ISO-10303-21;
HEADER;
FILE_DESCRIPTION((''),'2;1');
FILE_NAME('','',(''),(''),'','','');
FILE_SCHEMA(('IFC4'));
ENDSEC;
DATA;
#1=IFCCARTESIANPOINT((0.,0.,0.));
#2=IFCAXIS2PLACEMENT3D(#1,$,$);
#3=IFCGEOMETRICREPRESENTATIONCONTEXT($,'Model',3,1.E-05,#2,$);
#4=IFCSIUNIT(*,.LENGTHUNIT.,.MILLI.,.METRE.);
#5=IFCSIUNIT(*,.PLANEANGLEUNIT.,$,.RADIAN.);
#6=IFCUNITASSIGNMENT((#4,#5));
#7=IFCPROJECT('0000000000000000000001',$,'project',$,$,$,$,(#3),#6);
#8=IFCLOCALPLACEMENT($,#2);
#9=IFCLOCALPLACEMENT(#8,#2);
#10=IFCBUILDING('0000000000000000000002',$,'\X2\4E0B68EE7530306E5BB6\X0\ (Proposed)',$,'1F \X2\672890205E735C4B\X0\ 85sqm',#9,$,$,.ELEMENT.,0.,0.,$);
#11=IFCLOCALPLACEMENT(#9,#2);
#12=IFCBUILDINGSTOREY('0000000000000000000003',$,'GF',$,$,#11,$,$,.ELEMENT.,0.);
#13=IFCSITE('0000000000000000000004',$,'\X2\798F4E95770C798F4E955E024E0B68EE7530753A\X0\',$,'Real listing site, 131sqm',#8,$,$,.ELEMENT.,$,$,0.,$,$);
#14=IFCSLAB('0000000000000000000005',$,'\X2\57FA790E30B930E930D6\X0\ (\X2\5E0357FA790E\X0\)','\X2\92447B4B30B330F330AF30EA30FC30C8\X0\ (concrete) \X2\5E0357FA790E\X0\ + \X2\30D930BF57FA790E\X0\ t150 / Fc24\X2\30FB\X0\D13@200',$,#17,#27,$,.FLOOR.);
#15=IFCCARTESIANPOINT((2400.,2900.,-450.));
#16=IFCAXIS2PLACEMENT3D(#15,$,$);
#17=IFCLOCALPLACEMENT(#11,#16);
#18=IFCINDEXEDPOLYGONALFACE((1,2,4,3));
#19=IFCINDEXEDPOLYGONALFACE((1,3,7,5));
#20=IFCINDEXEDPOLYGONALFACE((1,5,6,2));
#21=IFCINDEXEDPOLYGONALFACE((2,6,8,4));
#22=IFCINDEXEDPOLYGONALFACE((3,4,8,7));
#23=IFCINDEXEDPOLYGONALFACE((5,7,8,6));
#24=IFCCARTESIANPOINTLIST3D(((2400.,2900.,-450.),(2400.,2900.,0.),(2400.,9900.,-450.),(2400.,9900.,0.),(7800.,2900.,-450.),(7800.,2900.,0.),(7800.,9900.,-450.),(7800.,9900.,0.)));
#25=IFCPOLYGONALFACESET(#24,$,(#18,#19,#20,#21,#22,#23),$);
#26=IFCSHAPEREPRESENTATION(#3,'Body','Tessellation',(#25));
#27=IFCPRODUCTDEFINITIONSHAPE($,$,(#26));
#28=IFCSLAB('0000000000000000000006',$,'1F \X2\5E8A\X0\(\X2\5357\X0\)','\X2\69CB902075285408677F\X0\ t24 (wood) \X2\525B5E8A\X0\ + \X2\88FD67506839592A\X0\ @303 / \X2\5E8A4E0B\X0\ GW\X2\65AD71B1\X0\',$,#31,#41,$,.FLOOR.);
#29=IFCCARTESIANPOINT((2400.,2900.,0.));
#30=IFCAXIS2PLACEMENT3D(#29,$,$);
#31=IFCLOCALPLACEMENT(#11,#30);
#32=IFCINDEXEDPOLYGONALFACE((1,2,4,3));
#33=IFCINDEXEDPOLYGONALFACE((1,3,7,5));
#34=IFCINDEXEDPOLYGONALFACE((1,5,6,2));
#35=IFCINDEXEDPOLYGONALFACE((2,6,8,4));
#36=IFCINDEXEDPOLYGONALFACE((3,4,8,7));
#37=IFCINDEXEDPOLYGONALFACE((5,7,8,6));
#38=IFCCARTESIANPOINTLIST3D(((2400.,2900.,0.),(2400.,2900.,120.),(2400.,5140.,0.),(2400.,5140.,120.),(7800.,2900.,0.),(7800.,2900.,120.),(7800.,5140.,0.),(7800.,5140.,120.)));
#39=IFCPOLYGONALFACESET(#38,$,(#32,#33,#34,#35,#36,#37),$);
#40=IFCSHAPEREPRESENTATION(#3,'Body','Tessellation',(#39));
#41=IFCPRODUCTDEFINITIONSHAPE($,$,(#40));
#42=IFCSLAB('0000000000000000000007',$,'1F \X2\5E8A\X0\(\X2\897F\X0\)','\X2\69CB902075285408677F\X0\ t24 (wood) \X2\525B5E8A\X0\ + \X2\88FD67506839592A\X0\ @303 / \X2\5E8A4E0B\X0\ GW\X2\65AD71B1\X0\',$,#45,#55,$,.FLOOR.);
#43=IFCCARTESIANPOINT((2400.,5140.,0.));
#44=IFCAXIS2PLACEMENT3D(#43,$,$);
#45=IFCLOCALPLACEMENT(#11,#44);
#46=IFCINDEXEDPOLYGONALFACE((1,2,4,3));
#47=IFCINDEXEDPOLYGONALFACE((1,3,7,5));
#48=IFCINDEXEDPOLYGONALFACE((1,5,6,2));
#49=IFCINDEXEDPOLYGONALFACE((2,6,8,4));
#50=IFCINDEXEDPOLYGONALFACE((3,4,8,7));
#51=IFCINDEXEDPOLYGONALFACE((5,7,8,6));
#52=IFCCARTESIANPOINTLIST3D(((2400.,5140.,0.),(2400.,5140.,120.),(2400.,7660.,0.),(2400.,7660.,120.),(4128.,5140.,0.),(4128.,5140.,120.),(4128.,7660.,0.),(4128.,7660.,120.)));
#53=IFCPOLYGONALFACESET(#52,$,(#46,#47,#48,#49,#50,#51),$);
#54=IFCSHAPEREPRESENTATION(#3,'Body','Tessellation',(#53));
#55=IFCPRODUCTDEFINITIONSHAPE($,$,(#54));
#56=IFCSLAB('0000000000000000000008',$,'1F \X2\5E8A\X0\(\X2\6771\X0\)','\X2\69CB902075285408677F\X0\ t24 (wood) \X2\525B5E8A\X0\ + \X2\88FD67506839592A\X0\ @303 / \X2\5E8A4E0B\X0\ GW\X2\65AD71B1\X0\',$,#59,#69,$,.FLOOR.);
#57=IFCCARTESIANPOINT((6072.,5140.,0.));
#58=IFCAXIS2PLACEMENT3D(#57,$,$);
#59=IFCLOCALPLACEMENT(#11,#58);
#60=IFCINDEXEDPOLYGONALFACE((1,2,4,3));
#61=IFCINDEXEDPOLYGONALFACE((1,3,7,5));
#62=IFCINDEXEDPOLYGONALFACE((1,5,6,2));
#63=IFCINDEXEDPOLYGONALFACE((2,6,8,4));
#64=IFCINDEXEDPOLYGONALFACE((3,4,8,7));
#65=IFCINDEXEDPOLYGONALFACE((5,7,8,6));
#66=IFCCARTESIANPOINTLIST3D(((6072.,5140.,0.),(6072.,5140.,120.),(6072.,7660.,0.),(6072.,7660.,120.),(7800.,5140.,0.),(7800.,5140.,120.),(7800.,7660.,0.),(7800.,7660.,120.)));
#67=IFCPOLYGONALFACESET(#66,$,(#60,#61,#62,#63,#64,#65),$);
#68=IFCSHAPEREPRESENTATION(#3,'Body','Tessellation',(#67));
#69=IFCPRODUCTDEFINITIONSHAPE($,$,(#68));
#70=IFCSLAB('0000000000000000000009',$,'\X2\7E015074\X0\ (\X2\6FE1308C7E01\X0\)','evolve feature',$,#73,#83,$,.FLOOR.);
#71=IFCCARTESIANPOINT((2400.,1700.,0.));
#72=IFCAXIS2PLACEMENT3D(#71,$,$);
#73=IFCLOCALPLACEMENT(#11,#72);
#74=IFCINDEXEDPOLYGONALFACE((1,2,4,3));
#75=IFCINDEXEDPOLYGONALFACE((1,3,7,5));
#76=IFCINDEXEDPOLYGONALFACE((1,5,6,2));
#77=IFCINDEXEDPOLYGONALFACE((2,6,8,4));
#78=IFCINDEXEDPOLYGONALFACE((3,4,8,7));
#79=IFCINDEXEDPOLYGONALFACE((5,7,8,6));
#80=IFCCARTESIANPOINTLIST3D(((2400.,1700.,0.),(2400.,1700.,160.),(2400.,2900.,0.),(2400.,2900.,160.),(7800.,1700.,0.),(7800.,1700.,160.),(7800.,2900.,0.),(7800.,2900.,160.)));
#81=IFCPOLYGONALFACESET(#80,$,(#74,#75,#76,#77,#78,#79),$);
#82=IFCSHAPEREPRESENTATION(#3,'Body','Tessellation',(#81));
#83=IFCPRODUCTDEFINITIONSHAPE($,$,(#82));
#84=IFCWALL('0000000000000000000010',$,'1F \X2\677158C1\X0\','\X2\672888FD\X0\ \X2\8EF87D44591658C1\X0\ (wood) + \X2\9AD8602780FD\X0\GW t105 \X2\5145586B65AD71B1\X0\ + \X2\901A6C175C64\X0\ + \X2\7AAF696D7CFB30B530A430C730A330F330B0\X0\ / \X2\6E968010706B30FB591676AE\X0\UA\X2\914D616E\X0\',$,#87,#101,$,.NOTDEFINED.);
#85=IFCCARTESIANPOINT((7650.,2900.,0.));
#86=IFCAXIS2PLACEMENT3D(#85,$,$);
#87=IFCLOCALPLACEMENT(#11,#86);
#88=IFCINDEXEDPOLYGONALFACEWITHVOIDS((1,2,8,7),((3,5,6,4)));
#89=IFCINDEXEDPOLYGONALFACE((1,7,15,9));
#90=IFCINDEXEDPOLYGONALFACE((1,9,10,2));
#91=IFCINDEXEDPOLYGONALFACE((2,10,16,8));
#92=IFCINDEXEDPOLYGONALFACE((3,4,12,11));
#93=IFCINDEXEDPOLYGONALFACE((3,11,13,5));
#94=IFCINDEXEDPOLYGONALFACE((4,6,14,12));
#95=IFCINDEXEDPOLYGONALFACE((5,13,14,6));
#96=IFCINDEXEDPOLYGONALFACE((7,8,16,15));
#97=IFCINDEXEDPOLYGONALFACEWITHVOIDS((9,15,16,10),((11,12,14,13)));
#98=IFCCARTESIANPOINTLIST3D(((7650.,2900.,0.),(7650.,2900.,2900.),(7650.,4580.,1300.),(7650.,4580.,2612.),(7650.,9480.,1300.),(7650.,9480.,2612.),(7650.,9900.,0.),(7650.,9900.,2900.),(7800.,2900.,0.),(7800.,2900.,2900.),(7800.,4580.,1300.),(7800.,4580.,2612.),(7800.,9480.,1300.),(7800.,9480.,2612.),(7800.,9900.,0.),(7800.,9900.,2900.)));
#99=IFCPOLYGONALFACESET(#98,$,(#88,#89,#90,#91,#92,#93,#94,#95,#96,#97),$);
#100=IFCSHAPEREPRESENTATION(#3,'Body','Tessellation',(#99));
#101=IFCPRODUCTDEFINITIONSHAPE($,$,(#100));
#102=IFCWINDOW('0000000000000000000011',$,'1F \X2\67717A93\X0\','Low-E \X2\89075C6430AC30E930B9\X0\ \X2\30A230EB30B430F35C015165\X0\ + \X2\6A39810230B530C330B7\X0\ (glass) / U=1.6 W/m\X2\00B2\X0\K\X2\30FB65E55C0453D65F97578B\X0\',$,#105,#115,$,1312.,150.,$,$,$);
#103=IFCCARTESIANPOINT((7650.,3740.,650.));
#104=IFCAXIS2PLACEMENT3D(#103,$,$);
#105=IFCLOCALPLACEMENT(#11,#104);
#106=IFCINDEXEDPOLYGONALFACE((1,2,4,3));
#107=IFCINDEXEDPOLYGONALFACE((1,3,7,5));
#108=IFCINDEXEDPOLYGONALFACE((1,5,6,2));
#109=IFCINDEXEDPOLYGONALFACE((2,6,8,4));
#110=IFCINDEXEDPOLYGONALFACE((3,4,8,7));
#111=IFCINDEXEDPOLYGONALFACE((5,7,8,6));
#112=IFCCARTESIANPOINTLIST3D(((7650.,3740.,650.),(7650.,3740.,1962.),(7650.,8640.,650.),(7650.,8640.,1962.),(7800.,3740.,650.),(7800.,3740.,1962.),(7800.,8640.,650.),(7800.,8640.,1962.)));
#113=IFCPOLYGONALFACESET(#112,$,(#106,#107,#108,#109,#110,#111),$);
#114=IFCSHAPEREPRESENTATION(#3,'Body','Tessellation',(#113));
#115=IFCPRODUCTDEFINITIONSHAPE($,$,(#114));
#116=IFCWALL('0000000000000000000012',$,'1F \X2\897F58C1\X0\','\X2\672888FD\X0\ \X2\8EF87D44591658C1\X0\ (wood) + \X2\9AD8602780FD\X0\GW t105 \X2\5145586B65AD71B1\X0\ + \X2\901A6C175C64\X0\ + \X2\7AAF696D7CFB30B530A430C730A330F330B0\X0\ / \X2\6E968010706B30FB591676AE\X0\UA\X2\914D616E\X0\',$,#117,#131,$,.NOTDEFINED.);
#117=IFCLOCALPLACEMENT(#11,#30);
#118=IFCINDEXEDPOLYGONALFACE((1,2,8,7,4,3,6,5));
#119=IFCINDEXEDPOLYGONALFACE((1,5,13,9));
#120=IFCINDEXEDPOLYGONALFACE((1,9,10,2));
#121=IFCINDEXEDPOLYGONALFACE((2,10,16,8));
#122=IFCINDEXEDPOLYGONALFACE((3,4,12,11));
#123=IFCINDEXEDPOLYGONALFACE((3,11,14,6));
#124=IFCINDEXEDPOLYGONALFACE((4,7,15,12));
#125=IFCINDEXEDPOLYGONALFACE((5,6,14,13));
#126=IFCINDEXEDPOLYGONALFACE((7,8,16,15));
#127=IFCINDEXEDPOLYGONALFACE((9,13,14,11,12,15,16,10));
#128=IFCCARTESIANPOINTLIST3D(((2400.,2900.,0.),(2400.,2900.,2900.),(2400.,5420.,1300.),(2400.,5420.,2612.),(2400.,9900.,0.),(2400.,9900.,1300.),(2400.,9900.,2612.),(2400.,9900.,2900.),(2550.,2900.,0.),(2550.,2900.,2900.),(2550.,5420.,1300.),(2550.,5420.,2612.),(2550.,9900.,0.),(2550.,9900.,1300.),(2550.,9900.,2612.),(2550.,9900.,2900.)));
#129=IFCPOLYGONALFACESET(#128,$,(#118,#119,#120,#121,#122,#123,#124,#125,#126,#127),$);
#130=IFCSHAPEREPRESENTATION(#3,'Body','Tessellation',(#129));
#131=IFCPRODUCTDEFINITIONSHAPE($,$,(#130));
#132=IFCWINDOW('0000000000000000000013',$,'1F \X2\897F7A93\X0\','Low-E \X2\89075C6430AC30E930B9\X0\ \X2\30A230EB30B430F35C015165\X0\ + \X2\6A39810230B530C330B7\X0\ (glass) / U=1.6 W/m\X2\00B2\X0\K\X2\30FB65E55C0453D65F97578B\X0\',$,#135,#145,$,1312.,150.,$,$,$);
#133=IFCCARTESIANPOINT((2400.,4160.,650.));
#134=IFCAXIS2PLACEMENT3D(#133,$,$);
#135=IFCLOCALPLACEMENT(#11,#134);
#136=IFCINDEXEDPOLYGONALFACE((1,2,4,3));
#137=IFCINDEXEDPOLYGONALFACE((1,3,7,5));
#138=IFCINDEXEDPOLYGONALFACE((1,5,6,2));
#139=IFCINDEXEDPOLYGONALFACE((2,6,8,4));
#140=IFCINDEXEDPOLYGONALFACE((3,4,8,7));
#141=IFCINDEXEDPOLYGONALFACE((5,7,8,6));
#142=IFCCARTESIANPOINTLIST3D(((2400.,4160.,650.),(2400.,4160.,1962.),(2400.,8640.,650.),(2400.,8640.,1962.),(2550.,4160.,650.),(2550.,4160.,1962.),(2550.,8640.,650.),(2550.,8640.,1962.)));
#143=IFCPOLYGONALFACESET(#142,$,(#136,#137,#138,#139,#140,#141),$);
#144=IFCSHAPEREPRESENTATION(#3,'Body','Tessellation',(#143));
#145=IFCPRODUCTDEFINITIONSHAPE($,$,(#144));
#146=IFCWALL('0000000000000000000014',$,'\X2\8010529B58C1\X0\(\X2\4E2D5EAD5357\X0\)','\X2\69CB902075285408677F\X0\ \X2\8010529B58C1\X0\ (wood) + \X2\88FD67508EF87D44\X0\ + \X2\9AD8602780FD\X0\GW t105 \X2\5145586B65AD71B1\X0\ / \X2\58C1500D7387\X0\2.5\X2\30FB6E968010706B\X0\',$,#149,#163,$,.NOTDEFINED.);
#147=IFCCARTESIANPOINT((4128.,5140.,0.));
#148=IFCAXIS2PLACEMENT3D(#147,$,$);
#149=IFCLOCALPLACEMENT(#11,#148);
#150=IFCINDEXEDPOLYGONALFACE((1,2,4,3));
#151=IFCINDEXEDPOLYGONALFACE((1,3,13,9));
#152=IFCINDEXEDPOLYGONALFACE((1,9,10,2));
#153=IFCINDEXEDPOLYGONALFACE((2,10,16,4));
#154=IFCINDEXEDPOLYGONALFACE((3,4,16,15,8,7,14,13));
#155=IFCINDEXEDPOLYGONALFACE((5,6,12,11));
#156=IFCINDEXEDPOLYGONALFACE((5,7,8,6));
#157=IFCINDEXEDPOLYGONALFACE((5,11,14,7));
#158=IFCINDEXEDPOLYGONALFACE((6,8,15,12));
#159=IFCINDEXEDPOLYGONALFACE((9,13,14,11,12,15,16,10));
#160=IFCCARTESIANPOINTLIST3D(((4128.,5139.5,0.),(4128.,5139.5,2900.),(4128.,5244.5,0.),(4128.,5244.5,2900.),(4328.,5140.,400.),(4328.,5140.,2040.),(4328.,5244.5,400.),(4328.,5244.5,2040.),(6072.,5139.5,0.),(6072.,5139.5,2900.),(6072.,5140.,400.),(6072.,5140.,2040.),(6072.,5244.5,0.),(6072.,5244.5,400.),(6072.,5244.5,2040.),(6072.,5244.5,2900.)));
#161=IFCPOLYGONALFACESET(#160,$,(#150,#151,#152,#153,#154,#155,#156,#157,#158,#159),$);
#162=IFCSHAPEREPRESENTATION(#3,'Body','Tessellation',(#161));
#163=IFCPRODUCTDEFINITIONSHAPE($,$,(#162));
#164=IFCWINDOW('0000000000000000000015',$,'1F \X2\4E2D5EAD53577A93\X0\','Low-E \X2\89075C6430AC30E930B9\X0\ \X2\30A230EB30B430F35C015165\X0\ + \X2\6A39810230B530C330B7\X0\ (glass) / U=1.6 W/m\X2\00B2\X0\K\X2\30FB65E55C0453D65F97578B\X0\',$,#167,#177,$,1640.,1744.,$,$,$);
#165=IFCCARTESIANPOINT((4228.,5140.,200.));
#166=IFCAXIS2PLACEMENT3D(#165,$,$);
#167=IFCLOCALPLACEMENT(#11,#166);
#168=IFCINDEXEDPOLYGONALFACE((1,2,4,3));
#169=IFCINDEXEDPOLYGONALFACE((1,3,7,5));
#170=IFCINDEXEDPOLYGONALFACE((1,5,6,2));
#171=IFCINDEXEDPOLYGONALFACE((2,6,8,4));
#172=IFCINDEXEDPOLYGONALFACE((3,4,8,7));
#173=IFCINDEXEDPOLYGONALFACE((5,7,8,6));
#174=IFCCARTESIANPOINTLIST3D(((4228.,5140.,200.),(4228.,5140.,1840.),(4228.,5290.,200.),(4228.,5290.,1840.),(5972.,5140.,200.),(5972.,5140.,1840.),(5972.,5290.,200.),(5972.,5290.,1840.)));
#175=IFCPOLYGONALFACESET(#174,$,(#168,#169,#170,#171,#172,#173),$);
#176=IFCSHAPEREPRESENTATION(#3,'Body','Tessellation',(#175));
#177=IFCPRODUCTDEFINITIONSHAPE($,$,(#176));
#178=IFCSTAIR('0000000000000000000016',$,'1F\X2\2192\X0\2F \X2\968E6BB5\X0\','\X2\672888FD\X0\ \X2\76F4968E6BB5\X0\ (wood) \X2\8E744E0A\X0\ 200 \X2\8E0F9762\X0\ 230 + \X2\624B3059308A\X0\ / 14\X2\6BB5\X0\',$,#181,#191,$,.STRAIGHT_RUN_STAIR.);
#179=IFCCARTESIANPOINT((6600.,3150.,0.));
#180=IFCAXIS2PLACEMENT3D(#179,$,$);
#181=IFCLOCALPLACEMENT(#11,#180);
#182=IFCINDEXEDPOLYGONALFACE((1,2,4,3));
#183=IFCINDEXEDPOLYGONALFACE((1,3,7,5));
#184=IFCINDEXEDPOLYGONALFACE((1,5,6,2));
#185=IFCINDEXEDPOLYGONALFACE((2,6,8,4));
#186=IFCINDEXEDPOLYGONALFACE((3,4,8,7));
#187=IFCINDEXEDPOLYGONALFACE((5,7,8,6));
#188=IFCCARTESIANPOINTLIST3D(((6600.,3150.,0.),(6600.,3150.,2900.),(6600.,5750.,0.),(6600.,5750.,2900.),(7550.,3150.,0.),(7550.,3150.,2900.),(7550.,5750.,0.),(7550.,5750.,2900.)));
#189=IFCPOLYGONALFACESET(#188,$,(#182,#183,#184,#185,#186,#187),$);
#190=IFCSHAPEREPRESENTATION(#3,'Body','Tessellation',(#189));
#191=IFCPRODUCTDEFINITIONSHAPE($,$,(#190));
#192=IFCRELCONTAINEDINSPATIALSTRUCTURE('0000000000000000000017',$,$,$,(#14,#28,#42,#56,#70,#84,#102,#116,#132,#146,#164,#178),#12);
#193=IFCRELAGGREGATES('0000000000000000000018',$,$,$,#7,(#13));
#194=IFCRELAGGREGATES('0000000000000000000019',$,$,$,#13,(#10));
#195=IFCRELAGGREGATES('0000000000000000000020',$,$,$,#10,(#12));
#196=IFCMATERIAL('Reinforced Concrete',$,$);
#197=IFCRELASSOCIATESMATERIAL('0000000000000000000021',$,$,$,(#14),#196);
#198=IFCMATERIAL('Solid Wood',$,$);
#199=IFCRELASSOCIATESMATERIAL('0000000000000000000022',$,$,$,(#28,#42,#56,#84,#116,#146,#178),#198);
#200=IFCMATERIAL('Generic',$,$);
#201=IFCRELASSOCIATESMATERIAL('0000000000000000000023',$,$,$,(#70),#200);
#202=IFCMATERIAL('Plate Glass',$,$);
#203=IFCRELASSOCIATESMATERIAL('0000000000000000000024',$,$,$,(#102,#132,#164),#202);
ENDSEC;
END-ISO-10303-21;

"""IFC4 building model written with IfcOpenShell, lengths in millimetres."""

from ifc_helpers import new_model, si_unit, frame, frame_2d, origin, place, context, project, spatial, rectangle, extrude, material, element, fill, save


model = new_model("IFC4")

# Units and contexts
model_context = context("Model", 3, precision=1e-05, world=origin())
ifc_project = project(units=[si_unit("LENGTHUNIT", "METRE", prefix="MILLI"), si_unit("PLANEANGLEUNIT", "RADIAN")], contexts=[model_context])

# Site, building, storey
site_placement = place(None, origin())
site = spatial("IfcSite", under=ifc_project, at=site_placement, Name="福井県福井市下森田町", ObjectType="Real listing site, 131sqm", CompositionType="ELEMENT", RefElevation=0.0)
building_placement = place(site_placement, origin())
building = spatial("IfcBuilding", under=site, at=building_placement, Name="下森田の家 (Proposed)", ObjectType="1F 木造平屋 85sqm", CompositionType="ELEMENT", ElevationOfRefHeight=0.0, ElevationOfTerrain=0.0)
storey_placement = place(building_placement, origin())
storey = spatial("IfcBuildingStorey", under=building, at=storey_placement, Name="GF", CompositionType="ELEMENT", Elevation=0.0)

# Slabs
ifc_material_1 = material(Name="Reinforced Concrete")
slab_1_placement = place(storey_placement, frame((2400.0, 2900.0, -450.0)))
element("IfcSlab", 1, at=slab_1_placement, inside=storey, material=ifc_material_1, Name="基礎スラブ (布基礎)", Description="鉄筋コンクリート (concrete) 布基礎 + ベタ基礎 t150 / Fc24・D13@200", PredefinedType="FLOOR", context=model_context, shape_type="SweptSolid", body=[
    extrude(rectangle(XDim=5400.0, YDim=7000.0, at=frame_2d((2700.0, 3500.0))), frame((2400.0, 2900.0, -450.0)), (0.0, 0.0, 1.0), 450.0),
])
ifc_material_2 = material(Name="Solid Wood")
slab_2_placement = place(storey_placement, frame((2400.0, 2900.0, 0.0)))
element("IfcSlab", 2, at=slab_2_placement, inside=storey, material=ifc_material_2, Name="1F 床(南)", Description="構造用合板 t24 (wood) 剛床 + 製材根太 @303 / 床下 GW断熱", PredefinedType="FLOOR", context=model_context, shape_type="SweptSolid", body=[
    extrude(rectangle(XDim=5400.0, YDim=2240.0, at=frame_2d((2700.0, 1120.0))), frame((2400.0, 2900.0, 0.0)), (0.0, 0.0, 1.0), 120.0),
])
slab_3_placement = place(storey_placement, frame((2400.0, 5140.0, 0.0)))
element("IfcSlab", 3, at=slab_3_placement, inside=storey, material=ifc_material_2, Name="1F 床(西)", Description="構造用合板 t24 (wood) 剛床 + 製材根太 @303 / 床下 GW断熱", PredefinedType="FLOOR", context=model_context, shape_type="SweptSolid", body=[
    extrude(rectangle(XDim=1728.0, YDim=2520.0, at=frame_2d((864.0, 1260.0))), frame((2400.0, 5140.0, 0.0)), (0.0, 0.0, 1.0), 120.0),
])
slab_4_placement = place(storey_placement, frame((6072.0, 5140.0, 0.0)))
element("IfcSlab", 4, at=slab_4_placement, inside=storey, material=ifc_material_2, Name="1F 床(東)", Description="構造用合板 t24 (wood) 剛床 + 製材根太 @303 / 床下 GW断熱", PredefinedType="FLOOR", context=model_context, shape_type="SweptSolid", body=[
    extrude(rectangle(XDim=1728.0, YDim=2520.0, at=frame_2d((864.0, 1260.0))), frame((6072.0, 5140.0, 0.0)), (0.0, 0.0, 1.0), 120.0),
])
ifc_material_3 = material(Name="Generic")
slab_5_placement = place(storey_placement, frame((2400.0, 1700.0, 0.0)))
element("IfcSlab", 5, at=slab_5_placement, inside=storey, material=ifc_material_3, Name="縁側 (濡れ縁)", Description="evolve feature", PredefinedType="FLOOR", context=model_context, shape_type="SweptSolid", body=[
    extrude(rectangle(XDim=5400.0, YDim=1200.0, at=frame_2d((2700.0, 600.0))), frame((2400.0, 1700.0, 0.0)), (0.0, 0.0, 1.0), 160.0),
])

# Shared definitions
ifc_material_4 = material(Name="Plate Glass")

# Walls, openings, windows
wall_1_placement = place(storey_placement, frame((7650.0, 2900.0, 0.0)))
wall_1 = element("IfcWall", 6, at=wall_1_placement, inside=storey, material=ifc_material_2, Name="1F 東壁", Description="木製 軸組外壁 (wood) + 高性能GW t105 充填断熱 + 通気層 + 窯業系サイディング / 準耐火・外皮UA配慮", PredefinedType="NOTDEFINED", context=model_context, shape_type="SweptSolid", body=[
    extrude(rectangle(XDim=150.0, YDim=7000.0, at=frame_2d((75.0, 3500.0))), frame((7650.0, 2900.0, 0.0)), (0.0, 0.0, 1.0), 2900.0),
])
opening_1_placement = place(storey_placement, frame((7650.0, 3740.0, 650.0)))
opening_1 = element("IfcOpeningElement", 7, at=opening_1_placement, cuts=wall_1, PredefinedType="NOTDEFINED", context=model_context, shape_type="SweptSolid", body=[
    extrude(rectangle(XDim=150.0, YDim=4900.0, at=frame_2d((75.0, 2450.0))), frame((7650.0, 3740.0, 650.0)), (0.0, 0.0, 1.0), 1312.0),
])
window_1_placement = place(storey_placement, frame((7650.0, 3740.0, 650.0)))
window_1 = element("IfcWindow", 8, at=window_1_placement, inside=storey, material=ifc_material_4, Name="1F 東窓", Description="Low-E 複層ガラス アルゴン封入 + 樹脂サッシ (glass) / U=1.6 W/m²K・日射取得型", OverallHeight=1312.0, OverallWidth=150.0, context=model_context, shape_type="SweptSolid", body=[
    extrude(rectangle(XDim=150.0, YDim=4900.0, at=frame_2d((75.0, 2450.0))), frame((7650.0, 3740.0, 650.0)), (0.0, 0.0, 1.0), 1312.0),
])
fill(opening_1, window_1)
wall_2_placement = place(storey_placement, frame((2400.0, 2900.0, 0.0)))
wall_2 = element("IfcWall", 9, at=wall_2_placement, inside=storey, material=ifc_material_2, Name="1F 西壁", Description="木製 軸組外壁 (wood) + 高性能GW t105 充填断熱 + 通気層 + 窯業系サイディング / 準耐火・外皮UA配慮", PredefinedType="NOTDEFINED", context=model_context, shape_type="SweptSolid", body=[
    extrude(rectangle(XDim=150.0, YDim=7000.0, at=frame_2d((75.0, 3500.0))), frame((2400.0, 2900.0, 0.0)), (0.0, 0.0, 1.0), 2900.0),
])
opening_2_placement = place(storey_placement, frame((2400.0, 4160.0, 650.0)))
opening_2 = element("IfcOpeningElement", 10, at=opening_2_placement, cuts=wall_2, PredefinedType="NOTDEFINED", context=model_context, shape_type="SweptSolid", body=[
    extrude(rectangle(XDim=150.0, YDim=4480.0, at=frame_2d((75.0, 2240.0))), frame((2400.0, 4160.0, 650.0)), (0.0, 0.0, 1.0), 1312.0),
])
window_2_placement = place(storey_placement, frame((2400.0, 4160.0, 650.0)))
window_2 = element("IfcWindow", 11, at=window_2_placement, inside=storey, material=ifc_material_4, Name="1F 西窓", Description="Low-E 複層ガラス アルゴン封入 + 樹脂サッシ (glass) / U=1.6 W/m²K・日射取得型", OverallHeight=1312.0, OverallWidth=150.0, context=model_context, shape_type="SweptSolid", body=[
    extrude(rectangle(XDim=150.0, YDim=4480.0, at=frame_2d((75.0, 2240.0))), frame((2400.0, 4160.0, 650.0)), (0.0, 0.0, 1.0), 1312.0),
])
fill(opening_2, window_2)
wall_3_placement = place(storey_placement, frame((4128.0, 5140.0, 0.0)))
wall_3 = element("IfcWall", 12, at=wall_3_placement, inside=storey, material=ifc_material_2, Name="耐力壁(中庭南)", Description="構造用合板 耐力壁 (wood) + 製材軸組 + 高性能GW t105 充填断熱 / 壁倍率2.5・準耐火", PredefinedType="NOTDEFINED", context=model_context, shape_type="SweptSolid", body=[
    extrude(rectangle(XDim=1944.0, YDim=105.0, at=frame_2d((972.0, 52.0))), frame((4128.0, 5140.0, 0.0)), (0.0, 0.0, 1.0), 2900.0),
])
opening_3_placement = place(storey_placement, frame((4228.0, 5140.0, 200.0)))
opening_3 = element("IfcOpeningElement", 13, at=opening_3_placement, cuts=wall_3, PredefinedType="NOTDEFINED", context=model_context, shape_type="SweptSolid", body=[
    extrude(rectangle(XDim=1744.0, YDim=150.0, at=frame_2d((872.0, 75.0))), frame((4228.0, 5140.0, 200.0)), (0.0, 0.0, 1.0), 1640.0),
])
window_3_placement = place(storey_placement, frame((4228.0, 5140.0, 200.0)))
window_3 = element("IfcWindow", 14, at=window_3_placement, inside=storey, material=ifc_material_4, Name="1F 中庭南窓", Description="Low-E 複層ガラス アルゴン封入 + 樹脂サッシ (glass) / U=1.6 W/m²K・日射取得型", OverallHeight=1640.0, OverallWidth=1744.0, context=model_context, shape_type="SweptSolid", body=[
    extrude(rectangle(XDim=1744.0, YDim=150.0, at=frame_2d((872.0, 75.0))), frame((4228.0, 5140.0, 200.0)), (0.0, 0.0, 1.0), 1640.0),
])
fill(opening_3, window_3)

# Stair
stair_placement = place(storey_placement, frame((6600.0, 3150.0, 0.0)))
element("IfcStair", 15, at=stair_placement, inside=storey, material=ifc_material_2, Name="1F→2F 階段", Description="木製 直階段 (wood) 蹴上 200 踏面 230 + 手すり / 14段", PredefinedType="STRAIGHT_RUN_STAIR", context=model_context, shape_type="SweptSolid", body=[
    extrude(rectangle(XDim=950.0, YDim=2600.0, at=frame_2d((475.0, 1300.0))), frame((6600.0, 3150.0, 0.0)), (0.0, 0.0, 1.0), 2900.0),
])

save(model, "model.ifc")
